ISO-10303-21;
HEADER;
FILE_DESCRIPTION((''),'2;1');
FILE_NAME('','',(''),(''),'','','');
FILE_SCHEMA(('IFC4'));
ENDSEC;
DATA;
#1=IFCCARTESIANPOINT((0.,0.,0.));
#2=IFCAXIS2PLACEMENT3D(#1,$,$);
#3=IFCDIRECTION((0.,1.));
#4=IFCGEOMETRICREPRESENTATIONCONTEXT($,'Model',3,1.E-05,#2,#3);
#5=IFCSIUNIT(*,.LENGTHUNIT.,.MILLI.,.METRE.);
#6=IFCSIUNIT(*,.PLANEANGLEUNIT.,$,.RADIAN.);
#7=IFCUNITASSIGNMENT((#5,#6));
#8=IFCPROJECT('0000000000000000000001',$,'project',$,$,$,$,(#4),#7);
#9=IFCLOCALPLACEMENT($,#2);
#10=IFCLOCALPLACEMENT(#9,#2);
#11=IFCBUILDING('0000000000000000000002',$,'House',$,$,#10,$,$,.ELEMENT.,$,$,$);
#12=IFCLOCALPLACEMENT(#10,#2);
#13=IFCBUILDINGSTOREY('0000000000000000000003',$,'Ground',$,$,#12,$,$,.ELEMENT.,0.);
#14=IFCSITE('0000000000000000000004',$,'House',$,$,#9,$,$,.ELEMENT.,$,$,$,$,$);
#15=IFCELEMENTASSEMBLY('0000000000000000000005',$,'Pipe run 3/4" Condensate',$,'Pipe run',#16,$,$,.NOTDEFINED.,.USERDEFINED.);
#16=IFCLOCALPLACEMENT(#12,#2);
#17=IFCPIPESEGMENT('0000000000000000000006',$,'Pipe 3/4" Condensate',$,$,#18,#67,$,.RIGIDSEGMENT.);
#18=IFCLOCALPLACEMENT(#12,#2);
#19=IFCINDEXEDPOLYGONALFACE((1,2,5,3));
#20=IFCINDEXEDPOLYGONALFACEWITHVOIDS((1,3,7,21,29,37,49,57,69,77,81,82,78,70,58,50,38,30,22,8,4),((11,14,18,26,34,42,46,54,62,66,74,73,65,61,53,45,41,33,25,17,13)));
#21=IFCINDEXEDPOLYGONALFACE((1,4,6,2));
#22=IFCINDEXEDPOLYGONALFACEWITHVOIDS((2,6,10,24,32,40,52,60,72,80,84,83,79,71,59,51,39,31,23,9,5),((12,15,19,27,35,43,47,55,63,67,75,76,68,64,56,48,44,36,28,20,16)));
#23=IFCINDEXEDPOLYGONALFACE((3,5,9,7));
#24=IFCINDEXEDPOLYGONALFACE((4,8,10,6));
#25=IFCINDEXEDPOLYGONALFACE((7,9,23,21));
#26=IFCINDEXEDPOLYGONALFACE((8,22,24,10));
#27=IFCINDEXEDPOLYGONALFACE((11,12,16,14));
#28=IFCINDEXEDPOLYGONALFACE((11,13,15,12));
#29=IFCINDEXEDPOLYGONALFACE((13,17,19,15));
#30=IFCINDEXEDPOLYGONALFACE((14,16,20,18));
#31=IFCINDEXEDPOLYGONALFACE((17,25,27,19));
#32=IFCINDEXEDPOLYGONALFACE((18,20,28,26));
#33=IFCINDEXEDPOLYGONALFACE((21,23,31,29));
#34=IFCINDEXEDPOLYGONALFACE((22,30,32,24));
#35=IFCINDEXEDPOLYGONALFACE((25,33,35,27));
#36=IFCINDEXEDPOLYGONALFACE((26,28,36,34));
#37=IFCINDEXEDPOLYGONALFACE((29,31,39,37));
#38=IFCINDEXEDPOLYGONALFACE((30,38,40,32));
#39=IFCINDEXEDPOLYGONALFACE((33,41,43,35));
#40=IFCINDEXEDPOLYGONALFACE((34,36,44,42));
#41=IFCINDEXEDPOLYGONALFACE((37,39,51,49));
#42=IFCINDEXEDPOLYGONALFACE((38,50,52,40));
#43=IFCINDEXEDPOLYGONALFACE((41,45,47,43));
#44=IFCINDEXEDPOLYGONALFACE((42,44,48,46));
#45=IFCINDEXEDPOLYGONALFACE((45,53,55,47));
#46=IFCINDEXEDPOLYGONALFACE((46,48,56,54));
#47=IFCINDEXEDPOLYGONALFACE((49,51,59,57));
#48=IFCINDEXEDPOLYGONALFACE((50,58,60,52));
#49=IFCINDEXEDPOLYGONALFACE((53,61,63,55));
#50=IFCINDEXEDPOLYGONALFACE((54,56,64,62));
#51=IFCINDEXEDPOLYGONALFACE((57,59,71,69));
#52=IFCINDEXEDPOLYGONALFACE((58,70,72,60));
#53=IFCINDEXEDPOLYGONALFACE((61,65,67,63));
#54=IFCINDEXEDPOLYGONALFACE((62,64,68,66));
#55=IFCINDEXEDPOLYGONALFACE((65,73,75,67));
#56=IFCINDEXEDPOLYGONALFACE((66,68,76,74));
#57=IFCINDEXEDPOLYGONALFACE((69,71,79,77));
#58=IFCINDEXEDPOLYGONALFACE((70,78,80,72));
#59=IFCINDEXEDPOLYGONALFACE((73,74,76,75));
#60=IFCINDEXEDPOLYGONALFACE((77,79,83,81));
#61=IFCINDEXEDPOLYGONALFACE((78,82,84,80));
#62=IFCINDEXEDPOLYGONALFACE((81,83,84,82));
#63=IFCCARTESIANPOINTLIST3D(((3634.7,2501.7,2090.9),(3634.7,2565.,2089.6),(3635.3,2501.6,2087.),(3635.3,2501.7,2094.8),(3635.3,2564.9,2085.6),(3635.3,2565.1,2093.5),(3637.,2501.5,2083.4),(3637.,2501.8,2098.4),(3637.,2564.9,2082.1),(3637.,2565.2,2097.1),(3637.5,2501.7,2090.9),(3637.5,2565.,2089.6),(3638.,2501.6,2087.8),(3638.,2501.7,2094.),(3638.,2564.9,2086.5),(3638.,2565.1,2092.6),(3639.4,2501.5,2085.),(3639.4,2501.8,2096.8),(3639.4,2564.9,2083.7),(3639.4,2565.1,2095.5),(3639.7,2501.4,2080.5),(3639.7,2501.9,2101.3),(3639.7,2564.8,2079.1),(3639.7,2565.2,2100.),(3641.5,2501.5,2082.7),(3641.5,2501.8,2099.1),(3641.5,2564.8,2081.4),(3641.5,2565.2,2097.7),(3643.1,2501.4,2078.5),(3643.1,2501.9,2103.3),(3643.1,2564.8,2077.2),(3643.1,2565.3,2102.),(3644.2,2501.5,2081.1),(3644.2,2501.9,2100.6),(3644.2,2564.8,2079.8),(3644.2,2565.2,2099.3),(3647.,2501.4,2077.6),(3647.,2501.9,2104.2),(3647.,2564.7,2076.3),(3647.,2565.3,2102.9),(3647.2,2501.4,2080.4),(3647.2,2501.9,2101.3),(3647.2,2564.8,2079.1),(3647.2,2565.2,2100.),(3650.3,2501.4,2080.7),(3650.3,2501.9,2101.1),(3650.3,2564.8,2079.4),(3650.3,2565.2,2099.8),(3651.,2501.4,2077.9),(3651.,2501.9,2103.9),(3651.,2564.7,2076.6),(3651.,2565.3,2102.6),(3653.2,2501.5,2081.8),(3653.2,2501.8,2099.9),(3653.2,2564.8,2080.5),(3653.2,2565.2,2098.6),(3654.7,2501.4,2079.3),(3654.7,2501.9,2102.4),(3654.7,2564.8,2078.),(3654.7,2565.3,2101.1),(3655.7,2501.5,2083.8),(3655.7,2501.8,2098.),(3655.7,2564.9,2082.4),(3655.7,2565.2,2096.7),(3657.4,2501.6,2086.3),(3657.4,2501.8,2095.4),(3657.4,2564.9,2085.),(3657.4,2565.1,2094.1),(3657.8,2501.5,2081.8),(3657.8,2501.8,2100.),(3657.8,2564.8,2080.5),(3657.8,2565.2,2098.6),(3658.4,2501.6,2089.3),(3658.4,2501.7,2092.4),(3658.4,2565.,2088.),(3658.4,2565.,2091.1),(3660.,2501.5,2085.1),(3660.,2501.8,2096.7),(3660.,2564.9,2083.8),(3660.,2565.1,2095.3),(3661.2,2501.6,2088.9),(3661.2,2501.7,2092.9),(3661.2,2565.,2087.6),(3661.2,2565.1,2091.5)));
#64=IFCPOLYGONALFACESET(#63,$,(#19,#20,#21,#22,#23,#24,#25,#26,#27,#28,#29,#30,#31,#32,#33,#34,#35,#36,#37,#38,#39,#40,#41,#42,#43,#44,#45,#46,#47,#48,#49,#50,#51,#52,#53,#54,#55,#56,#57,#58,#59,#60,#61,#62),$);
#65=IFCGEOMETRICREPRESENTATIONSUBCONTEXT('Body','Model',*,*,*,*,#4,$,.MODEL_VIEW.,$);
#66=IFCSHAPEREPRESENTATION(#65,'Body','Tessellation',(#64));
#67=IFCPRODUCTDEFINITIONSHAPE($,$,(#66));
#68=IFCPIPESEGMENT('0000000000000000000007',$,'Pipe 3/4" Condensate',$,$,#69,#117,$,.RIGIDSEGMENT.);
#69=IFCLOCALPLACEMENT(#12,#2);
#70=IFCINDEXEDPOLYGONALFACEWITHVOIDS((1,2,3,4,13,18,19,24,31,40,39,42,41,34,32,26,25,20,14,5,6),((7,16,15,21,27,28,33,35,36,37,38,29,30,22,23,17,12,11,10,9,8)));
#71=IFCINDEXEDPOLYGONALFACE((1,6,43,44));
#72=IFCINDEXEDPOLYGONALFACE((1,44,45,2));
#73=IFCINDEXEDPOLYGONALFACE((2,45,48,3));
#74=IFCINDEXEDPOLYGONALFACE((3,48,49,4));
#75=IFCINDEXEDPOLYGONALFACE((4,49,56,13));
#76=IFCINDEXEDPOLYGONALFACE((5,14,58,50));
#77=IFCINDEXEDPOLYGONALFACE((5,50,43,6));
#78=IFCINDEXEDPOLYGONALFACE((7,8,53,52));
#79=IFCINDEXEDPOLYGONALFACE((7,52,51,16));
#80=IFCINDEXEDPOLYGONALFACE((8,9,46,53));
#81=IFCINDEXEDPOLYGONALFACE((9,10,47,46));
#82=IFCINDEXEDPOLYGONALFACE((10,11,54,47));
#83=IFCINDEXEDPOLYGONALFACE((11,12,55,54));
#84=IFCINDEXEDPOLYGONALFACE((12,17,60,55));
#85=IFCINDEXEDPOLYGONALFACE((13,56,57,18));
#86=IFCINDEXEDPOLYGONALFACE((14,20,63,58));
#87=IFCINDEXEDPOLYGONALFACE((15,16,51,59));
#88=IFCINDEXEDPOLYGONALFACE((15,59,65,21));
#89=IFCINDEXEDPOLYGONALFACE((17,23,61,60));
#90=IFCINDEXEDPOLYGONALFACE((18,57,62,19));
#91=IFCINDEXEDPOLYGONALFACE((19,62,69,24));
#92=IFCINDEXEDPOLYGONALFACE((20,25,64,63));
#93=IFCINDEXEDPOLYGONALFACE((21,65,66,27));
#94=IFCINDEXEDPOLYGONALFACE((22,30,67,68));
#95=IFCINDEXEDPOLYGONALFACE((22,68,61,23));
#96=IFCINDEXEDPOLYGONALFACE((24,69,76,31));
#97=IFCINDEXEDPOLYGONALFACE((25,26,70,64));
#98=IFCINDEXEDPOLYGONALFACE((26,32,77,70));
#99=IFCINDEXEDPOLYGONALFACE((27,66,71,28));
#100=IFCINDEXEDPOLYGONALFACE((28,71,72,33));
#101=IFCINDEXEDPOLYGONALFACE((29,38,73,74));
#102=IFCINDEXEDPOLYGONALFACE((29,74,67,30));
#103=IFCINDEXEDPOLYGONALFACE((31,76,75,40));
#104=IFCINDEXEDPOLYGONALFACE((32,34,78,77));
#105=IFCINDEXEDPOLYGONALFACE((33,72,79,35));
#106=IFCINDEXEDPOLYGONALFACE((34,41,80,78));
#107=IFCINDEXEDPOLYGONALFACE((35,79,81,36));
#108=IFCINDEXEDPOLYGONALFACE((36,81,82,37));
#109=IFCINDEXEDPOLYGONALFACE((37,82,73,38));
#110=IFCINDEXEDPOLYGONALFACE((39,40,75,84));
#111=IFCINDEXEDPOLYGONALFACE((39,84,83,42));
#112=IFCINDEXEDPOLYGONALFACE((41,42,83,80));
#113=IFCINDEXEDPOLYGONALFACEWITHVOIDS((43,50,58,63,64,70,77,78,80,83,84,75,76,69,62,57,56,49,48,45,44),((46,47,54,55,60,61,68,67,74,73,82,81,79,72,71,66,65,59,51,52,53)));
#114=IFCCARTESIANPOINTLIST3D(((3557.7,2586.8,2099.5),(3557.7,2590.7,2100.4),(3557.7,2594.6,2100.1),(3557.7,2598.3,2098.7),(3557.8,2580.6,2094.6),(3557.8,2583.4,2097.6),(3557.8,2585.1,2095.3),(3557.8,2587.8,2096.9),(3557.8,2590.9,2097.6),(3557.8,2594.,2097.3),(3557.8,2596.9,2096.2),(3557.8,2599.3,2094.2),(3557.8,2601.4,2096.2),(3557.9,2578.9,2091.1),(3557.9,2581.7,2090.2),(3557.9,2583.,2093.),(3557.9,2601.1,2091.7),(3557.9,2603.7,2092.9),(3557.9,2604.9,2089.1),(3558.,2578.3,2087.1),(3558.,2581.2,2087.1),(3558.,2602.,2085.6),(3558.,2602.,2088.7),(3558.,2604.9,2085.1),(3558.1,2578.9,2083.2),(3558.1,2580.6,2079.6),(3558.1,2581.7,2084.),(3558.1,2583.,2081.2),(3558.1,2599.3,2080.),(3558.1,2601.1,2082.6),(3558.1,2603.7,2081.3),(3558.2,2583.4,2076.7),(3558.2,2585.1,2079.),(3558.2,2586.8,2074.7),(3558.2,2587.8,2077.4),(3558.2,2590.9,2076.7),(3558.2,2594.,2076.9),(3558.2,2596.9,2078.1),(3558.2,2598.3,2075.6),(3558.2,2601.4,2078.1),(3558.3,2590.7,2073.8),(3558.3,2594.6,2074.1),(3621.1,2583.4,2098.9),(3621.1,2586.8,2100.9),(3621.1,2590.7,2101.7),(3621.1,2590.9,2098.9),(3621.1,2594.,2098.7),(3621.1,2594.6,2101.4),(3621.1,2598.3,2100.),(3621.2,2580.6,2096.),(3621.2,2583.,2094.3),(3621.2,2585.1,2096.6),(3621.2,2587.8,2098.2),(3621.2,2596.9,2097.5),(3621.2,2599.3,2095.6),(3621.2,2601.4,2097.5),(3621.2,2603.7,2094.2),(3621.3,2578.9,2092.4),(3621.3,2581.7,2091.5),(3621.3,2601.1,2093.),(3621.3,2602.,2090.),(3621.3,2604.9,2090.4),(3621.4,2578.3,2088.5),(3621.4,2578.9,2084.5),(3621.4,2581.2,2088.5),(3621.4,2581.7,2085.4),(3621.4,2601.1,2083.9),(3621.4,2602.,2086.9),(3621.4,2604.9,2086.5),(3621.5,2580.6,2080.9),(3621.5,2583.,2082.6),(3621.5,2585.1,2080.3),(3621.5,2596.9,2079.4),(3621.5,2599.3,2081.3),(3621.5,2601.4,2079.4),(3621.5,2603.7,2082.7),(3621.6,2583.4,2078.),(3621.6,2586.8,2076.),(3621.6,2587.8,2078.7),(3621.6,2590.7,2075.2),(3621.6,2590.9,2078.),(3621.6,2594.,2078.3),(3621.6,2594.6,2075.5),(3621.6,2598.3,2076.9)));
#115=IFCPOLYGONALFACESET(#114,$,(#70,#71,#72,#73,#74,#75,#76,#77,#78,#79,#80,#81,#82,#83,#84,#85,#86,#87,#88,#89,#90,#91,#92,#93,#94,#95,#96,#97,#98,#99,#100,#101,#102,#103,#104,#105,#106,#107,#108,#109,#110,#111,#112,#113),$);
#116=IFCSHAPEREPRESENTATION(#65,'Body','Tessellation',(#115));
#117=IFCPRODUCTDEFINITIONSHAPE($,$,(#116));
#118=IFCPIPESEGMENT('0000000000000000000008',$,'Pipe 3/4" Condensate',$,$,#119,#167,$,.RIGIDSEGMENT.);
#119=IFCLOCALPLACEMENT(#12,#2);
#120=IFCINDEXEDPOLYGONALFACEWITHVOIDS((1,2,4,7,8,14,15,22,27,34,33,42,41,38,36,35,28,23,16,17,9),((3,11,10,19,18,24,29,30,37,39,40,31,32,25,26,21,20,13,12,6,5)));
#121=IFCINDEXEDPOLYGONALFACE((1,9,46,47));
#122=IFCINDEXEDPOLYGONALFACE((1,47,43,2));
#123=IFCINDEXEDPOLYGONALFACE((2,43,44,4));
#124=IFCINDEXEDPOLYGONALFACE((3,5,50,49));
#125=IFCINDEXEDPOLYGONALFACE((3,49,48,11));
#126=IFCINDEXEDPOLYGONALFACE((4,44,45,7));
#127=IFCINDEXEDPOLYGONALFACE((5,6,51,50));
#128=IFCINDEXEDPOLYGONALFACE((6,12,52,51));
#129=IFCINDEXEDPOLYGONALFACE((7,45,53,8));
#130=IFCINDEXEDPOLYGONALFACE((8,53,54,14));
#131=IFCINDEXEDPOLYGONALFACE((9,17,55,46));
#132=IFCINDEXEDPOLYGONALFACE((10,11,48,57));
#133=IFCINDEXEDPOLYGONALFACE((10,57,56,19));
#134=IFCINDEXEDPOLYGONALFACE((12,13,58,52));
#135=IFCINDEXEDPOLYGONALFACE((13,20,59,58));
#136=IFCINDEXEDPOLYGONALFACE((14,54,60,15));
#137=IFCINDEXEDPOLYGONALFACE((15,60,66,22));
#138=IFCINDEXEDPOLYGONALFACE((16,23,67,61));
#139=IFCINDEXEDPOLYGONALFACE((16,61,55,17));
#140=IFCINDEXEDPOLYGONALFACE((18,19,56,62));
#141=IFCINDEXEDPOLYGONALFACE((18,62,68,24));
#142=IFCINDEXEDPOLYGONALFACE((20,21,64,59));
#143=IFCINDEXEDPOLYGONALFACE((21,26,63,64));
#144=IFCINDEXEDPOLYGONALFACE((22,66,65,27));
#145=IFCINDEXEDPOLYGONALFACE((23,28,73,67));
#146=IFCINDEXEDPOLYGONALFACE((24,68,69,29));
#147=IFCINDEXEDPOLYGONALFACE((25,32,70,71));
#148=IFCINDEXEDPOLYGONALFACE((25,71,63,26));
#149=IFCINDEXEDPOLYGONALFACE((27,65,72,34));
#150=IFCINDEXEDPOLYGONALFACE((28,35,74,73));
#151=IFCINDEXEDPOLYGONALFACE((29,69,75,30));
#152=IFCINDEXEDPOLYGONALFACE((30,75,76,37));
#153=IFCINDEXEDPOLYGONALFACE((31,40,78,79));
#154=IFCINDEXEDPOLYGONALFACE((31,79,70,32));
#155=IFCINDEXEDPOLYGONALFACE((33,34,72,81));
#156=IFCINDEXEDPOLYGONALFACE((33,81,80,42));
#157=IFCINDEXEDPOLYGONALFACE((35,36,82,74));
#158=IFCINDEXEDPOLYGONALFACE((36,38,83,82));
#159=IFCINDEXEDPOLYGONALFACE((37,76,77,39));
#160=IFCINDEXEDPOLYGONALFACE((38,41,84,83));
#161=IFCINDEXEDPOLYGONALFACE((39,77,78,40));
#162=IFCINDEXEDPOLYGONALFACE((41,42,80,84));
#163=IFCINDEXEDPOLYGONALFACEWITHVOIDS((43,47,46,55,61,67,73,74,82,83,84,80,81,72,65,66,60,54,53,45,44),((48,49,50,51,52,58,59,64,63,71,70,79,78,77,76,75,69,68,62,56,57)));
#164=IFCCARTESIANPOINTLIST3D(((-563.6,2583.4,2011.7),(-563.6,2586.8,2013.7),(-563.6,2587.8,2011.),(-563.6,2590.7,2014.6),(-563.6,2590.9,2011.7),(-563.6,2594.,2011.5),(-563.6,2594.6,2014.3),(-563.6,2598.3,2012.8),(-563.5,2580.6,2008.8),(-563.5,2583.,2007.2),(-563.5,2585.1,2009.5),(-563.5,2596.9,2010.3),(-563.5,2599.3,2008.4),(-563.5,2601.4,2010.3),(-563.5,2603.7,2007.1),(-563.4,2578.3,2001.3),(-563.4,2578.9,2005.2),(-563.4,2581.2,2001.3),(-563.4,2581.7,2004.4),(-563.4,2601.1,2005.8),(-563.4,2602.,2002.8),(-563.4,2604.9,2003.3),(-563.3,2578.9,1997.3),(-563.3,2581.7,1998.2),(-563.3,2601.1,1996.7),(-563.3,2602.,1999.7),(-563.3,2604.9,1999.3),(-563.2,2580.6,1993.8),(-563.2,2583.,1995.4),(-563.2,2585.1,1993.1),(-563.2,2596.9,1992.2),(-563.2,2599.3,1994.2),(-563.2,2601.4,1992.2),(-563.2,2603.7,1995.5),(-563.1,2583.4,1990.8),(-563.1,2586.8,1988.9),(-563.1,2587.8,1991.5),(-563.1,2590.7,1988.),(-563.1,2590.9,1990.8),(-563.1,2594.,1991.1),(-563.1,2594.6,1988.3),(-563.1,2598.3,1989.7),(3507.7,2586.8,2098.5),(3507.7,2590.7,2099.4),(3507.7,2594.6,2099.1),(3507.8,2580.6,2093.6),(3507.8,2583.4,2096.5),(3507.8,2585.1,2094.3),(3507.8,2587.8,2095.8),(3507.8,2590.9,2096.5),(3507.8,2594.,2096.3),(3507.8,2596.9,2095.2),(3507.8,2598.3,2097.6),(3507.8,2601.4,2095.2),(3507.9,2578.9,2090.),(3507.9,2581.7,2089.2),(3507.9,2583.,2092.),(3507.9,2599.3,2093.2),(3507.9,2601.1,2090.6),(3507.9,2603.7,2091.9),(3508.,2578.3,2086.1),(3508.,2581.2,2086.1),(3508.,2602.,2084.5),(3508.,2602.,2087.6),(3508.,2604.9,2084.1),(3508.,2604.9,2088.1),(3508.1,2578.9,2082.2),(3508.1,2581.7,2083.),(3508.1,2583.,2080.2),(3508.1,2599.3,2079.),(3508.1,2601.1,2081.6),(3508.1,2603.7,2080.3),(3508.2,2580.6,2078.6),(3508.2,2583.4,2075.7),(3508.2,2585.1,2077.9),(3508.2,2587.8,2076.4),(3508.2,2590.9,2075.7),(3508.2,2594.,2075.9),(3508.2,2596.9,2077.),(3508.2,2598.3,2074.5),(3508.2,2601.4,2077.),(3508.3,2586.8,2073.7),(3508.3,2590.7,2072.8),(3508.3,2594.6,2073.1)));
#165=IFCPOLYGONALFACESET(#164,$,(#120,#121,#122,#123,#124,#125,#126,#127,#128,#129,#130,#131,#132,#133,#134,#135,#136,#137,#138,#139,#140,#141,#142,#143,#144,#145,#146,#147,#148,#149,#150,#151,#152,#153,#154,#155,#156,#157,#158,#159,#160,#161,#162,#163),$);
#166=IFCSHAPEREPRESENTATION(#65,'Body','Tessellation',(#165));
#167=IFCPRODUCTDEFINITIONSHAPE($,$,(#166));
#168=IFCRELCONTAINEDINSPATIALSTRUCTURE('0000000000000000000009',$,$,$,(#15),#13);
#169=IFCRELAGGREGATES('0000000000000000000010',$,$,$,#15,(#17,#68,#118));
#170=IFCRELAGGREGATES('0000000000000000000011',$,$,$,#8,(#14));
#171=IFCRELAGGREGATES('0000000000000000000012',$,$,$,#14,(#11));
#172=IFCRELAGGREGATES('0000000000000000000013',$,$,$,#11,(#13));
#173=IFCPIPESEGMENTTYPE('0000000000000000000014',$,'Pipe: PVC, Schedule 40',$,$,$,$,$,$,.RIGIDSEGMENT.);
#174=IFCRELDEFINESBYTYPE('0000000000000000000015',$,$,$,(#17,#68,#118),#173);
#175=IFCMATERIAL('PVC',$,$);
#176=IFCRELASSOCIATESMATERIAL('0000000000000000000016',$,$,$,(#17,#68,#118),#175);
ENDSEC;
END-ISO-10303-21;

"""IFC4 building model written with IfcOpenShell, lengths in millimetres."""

from ifc_helpers import new_model, si_unit, direction, frame, origin, origin_with_axes, origin_2d, place, context, subcontext, project, spatial, hollow_circle, extrude, material, type_object, element, aggregate, save


model = new_model("IFC4")

# Units and contexts
model_context = context("Model", 3, precision=1e-05, world=origin(), true_north=direction((0.0, 1.0)))
body_context = subcontext(model_context, "Body", "Model", "MODEL_VIEW")
ifc_project = project(units=[si_unit("LENGTHUNIT", "METRE", prefix="MILLI"), si_unit("PLANEANGLEUNIT", "RADIAN")], contexts=[model_context])

# Site, building, storey
site_placement = place(None, origin())
site = spatial("IfcSite", under=ifc_project, at=site_placement, Name="House", CompositionType="ELEMENT")
building_placement = place(site_placement, origin())
building = spatial("IfcBuilding", under=site, at=building_placement, Name="House", CompositionType="ELEMENT")
storey_placement = place(building_placement, origin())
storey = spatial("IfcBuildingStorey", under=building, at=storey_placement, Name="Ground", CompositionType="ELEMENT", Elevation=0.0)

# Element assembly
ifc_material_1 = material(Name="PVC")
assembly_1_placement = place(storey_placement, origin_with_axes())
assembly_1 = element("IfcElementAssembly", 1, at=assembly_1_placement, inside=storey, Name="Pipe run 3/4\" Condensate", ObjectType="Pipe run", AssemblyPlace="NOTDEFINED", PredefinedType="USERDEFINED")

# Pipe segments
pipe_segment_type_1 = type_object("IfcPipeSegmentType", Name="Pipe: PVC, Schedule 40", PredefinedType="RIGIDSEGMENT")
pipe_segment_1_placement = place(storey_placement, origin_with_axes())
pipe_segment_1 = element("IfcPipeSegment", 2, at=pipe_segment_1_placement, type_object=pipe_segment_type_1, material=ifc_material_1, Name="Pipe 3/4\" Condensate", PredefinedType="RIGIDSEGMENT", context=body_context, shape_type="SweptSolid", body=[
    extrude(hollow_circle(Radius=13.3, WallThickness=2.9, at=origin_2d()), frame((3648.0, 2501.7, 2090.9), z_axis=(0.0, 0.999783, -0.020829), x_axis=(-1.0, 0.0, 0.0)), (0.0, 0.0, 1.0), 63.4),
])
pipe_segment_2_placement = place(storey_placement, origin_with_axes())
pipe_segment_2 = element("IfcPipeSegment", 3, at=pipe_segment_2_placement, type_object=pipe_segment_type_1, material=ifc_material_1, Name="Pipe 3/4\" Condensate", PredefinedType="RIGIDSEGMENT", context=body_context, shape_type="SweptSolid", body=[
    extrude(hollow_circle(Radius=13.3, WallThickness=2.9, at=origin_2d()), frame((3621.4, 2591.7, 2088.5), z_axis=(-0.999783, 0.0, -0.020829), x_axis=(0.0, -1.0, 0.0)), (0.0, 0.0, 1.0), 63.4),
])
pipe_segment_3_placement = place(storey_placement, origin_with_axes())
pipe_segment_3 = element("IfcPipeSegment", 4, at=pipe_segment_3_placement, type_object=pipe_segment_type_1, material=ifc_material_1, Name="Pipe 3/4\" Condensate", PredefinedType="RIGIDSEGMENT", context=body_context, shape_type="SweptSolid", body=[
    extrude(hollow_circle(Radius=13.3, WallThickness=2.9, at=origin_2d()), frame((3508.0, 2591.7, 2086.1), z_axis=(-0.999783, 0.0, -0.020829), x_axis=(0.0, -1.0, 0.0)), (0.0, 0.0, 1.0), 4072.2),
])
aggregate(assembly_1, [pipe_segment_1, pipe_segment_2, pipe_segment_3])

save(model, "model.ifc")
